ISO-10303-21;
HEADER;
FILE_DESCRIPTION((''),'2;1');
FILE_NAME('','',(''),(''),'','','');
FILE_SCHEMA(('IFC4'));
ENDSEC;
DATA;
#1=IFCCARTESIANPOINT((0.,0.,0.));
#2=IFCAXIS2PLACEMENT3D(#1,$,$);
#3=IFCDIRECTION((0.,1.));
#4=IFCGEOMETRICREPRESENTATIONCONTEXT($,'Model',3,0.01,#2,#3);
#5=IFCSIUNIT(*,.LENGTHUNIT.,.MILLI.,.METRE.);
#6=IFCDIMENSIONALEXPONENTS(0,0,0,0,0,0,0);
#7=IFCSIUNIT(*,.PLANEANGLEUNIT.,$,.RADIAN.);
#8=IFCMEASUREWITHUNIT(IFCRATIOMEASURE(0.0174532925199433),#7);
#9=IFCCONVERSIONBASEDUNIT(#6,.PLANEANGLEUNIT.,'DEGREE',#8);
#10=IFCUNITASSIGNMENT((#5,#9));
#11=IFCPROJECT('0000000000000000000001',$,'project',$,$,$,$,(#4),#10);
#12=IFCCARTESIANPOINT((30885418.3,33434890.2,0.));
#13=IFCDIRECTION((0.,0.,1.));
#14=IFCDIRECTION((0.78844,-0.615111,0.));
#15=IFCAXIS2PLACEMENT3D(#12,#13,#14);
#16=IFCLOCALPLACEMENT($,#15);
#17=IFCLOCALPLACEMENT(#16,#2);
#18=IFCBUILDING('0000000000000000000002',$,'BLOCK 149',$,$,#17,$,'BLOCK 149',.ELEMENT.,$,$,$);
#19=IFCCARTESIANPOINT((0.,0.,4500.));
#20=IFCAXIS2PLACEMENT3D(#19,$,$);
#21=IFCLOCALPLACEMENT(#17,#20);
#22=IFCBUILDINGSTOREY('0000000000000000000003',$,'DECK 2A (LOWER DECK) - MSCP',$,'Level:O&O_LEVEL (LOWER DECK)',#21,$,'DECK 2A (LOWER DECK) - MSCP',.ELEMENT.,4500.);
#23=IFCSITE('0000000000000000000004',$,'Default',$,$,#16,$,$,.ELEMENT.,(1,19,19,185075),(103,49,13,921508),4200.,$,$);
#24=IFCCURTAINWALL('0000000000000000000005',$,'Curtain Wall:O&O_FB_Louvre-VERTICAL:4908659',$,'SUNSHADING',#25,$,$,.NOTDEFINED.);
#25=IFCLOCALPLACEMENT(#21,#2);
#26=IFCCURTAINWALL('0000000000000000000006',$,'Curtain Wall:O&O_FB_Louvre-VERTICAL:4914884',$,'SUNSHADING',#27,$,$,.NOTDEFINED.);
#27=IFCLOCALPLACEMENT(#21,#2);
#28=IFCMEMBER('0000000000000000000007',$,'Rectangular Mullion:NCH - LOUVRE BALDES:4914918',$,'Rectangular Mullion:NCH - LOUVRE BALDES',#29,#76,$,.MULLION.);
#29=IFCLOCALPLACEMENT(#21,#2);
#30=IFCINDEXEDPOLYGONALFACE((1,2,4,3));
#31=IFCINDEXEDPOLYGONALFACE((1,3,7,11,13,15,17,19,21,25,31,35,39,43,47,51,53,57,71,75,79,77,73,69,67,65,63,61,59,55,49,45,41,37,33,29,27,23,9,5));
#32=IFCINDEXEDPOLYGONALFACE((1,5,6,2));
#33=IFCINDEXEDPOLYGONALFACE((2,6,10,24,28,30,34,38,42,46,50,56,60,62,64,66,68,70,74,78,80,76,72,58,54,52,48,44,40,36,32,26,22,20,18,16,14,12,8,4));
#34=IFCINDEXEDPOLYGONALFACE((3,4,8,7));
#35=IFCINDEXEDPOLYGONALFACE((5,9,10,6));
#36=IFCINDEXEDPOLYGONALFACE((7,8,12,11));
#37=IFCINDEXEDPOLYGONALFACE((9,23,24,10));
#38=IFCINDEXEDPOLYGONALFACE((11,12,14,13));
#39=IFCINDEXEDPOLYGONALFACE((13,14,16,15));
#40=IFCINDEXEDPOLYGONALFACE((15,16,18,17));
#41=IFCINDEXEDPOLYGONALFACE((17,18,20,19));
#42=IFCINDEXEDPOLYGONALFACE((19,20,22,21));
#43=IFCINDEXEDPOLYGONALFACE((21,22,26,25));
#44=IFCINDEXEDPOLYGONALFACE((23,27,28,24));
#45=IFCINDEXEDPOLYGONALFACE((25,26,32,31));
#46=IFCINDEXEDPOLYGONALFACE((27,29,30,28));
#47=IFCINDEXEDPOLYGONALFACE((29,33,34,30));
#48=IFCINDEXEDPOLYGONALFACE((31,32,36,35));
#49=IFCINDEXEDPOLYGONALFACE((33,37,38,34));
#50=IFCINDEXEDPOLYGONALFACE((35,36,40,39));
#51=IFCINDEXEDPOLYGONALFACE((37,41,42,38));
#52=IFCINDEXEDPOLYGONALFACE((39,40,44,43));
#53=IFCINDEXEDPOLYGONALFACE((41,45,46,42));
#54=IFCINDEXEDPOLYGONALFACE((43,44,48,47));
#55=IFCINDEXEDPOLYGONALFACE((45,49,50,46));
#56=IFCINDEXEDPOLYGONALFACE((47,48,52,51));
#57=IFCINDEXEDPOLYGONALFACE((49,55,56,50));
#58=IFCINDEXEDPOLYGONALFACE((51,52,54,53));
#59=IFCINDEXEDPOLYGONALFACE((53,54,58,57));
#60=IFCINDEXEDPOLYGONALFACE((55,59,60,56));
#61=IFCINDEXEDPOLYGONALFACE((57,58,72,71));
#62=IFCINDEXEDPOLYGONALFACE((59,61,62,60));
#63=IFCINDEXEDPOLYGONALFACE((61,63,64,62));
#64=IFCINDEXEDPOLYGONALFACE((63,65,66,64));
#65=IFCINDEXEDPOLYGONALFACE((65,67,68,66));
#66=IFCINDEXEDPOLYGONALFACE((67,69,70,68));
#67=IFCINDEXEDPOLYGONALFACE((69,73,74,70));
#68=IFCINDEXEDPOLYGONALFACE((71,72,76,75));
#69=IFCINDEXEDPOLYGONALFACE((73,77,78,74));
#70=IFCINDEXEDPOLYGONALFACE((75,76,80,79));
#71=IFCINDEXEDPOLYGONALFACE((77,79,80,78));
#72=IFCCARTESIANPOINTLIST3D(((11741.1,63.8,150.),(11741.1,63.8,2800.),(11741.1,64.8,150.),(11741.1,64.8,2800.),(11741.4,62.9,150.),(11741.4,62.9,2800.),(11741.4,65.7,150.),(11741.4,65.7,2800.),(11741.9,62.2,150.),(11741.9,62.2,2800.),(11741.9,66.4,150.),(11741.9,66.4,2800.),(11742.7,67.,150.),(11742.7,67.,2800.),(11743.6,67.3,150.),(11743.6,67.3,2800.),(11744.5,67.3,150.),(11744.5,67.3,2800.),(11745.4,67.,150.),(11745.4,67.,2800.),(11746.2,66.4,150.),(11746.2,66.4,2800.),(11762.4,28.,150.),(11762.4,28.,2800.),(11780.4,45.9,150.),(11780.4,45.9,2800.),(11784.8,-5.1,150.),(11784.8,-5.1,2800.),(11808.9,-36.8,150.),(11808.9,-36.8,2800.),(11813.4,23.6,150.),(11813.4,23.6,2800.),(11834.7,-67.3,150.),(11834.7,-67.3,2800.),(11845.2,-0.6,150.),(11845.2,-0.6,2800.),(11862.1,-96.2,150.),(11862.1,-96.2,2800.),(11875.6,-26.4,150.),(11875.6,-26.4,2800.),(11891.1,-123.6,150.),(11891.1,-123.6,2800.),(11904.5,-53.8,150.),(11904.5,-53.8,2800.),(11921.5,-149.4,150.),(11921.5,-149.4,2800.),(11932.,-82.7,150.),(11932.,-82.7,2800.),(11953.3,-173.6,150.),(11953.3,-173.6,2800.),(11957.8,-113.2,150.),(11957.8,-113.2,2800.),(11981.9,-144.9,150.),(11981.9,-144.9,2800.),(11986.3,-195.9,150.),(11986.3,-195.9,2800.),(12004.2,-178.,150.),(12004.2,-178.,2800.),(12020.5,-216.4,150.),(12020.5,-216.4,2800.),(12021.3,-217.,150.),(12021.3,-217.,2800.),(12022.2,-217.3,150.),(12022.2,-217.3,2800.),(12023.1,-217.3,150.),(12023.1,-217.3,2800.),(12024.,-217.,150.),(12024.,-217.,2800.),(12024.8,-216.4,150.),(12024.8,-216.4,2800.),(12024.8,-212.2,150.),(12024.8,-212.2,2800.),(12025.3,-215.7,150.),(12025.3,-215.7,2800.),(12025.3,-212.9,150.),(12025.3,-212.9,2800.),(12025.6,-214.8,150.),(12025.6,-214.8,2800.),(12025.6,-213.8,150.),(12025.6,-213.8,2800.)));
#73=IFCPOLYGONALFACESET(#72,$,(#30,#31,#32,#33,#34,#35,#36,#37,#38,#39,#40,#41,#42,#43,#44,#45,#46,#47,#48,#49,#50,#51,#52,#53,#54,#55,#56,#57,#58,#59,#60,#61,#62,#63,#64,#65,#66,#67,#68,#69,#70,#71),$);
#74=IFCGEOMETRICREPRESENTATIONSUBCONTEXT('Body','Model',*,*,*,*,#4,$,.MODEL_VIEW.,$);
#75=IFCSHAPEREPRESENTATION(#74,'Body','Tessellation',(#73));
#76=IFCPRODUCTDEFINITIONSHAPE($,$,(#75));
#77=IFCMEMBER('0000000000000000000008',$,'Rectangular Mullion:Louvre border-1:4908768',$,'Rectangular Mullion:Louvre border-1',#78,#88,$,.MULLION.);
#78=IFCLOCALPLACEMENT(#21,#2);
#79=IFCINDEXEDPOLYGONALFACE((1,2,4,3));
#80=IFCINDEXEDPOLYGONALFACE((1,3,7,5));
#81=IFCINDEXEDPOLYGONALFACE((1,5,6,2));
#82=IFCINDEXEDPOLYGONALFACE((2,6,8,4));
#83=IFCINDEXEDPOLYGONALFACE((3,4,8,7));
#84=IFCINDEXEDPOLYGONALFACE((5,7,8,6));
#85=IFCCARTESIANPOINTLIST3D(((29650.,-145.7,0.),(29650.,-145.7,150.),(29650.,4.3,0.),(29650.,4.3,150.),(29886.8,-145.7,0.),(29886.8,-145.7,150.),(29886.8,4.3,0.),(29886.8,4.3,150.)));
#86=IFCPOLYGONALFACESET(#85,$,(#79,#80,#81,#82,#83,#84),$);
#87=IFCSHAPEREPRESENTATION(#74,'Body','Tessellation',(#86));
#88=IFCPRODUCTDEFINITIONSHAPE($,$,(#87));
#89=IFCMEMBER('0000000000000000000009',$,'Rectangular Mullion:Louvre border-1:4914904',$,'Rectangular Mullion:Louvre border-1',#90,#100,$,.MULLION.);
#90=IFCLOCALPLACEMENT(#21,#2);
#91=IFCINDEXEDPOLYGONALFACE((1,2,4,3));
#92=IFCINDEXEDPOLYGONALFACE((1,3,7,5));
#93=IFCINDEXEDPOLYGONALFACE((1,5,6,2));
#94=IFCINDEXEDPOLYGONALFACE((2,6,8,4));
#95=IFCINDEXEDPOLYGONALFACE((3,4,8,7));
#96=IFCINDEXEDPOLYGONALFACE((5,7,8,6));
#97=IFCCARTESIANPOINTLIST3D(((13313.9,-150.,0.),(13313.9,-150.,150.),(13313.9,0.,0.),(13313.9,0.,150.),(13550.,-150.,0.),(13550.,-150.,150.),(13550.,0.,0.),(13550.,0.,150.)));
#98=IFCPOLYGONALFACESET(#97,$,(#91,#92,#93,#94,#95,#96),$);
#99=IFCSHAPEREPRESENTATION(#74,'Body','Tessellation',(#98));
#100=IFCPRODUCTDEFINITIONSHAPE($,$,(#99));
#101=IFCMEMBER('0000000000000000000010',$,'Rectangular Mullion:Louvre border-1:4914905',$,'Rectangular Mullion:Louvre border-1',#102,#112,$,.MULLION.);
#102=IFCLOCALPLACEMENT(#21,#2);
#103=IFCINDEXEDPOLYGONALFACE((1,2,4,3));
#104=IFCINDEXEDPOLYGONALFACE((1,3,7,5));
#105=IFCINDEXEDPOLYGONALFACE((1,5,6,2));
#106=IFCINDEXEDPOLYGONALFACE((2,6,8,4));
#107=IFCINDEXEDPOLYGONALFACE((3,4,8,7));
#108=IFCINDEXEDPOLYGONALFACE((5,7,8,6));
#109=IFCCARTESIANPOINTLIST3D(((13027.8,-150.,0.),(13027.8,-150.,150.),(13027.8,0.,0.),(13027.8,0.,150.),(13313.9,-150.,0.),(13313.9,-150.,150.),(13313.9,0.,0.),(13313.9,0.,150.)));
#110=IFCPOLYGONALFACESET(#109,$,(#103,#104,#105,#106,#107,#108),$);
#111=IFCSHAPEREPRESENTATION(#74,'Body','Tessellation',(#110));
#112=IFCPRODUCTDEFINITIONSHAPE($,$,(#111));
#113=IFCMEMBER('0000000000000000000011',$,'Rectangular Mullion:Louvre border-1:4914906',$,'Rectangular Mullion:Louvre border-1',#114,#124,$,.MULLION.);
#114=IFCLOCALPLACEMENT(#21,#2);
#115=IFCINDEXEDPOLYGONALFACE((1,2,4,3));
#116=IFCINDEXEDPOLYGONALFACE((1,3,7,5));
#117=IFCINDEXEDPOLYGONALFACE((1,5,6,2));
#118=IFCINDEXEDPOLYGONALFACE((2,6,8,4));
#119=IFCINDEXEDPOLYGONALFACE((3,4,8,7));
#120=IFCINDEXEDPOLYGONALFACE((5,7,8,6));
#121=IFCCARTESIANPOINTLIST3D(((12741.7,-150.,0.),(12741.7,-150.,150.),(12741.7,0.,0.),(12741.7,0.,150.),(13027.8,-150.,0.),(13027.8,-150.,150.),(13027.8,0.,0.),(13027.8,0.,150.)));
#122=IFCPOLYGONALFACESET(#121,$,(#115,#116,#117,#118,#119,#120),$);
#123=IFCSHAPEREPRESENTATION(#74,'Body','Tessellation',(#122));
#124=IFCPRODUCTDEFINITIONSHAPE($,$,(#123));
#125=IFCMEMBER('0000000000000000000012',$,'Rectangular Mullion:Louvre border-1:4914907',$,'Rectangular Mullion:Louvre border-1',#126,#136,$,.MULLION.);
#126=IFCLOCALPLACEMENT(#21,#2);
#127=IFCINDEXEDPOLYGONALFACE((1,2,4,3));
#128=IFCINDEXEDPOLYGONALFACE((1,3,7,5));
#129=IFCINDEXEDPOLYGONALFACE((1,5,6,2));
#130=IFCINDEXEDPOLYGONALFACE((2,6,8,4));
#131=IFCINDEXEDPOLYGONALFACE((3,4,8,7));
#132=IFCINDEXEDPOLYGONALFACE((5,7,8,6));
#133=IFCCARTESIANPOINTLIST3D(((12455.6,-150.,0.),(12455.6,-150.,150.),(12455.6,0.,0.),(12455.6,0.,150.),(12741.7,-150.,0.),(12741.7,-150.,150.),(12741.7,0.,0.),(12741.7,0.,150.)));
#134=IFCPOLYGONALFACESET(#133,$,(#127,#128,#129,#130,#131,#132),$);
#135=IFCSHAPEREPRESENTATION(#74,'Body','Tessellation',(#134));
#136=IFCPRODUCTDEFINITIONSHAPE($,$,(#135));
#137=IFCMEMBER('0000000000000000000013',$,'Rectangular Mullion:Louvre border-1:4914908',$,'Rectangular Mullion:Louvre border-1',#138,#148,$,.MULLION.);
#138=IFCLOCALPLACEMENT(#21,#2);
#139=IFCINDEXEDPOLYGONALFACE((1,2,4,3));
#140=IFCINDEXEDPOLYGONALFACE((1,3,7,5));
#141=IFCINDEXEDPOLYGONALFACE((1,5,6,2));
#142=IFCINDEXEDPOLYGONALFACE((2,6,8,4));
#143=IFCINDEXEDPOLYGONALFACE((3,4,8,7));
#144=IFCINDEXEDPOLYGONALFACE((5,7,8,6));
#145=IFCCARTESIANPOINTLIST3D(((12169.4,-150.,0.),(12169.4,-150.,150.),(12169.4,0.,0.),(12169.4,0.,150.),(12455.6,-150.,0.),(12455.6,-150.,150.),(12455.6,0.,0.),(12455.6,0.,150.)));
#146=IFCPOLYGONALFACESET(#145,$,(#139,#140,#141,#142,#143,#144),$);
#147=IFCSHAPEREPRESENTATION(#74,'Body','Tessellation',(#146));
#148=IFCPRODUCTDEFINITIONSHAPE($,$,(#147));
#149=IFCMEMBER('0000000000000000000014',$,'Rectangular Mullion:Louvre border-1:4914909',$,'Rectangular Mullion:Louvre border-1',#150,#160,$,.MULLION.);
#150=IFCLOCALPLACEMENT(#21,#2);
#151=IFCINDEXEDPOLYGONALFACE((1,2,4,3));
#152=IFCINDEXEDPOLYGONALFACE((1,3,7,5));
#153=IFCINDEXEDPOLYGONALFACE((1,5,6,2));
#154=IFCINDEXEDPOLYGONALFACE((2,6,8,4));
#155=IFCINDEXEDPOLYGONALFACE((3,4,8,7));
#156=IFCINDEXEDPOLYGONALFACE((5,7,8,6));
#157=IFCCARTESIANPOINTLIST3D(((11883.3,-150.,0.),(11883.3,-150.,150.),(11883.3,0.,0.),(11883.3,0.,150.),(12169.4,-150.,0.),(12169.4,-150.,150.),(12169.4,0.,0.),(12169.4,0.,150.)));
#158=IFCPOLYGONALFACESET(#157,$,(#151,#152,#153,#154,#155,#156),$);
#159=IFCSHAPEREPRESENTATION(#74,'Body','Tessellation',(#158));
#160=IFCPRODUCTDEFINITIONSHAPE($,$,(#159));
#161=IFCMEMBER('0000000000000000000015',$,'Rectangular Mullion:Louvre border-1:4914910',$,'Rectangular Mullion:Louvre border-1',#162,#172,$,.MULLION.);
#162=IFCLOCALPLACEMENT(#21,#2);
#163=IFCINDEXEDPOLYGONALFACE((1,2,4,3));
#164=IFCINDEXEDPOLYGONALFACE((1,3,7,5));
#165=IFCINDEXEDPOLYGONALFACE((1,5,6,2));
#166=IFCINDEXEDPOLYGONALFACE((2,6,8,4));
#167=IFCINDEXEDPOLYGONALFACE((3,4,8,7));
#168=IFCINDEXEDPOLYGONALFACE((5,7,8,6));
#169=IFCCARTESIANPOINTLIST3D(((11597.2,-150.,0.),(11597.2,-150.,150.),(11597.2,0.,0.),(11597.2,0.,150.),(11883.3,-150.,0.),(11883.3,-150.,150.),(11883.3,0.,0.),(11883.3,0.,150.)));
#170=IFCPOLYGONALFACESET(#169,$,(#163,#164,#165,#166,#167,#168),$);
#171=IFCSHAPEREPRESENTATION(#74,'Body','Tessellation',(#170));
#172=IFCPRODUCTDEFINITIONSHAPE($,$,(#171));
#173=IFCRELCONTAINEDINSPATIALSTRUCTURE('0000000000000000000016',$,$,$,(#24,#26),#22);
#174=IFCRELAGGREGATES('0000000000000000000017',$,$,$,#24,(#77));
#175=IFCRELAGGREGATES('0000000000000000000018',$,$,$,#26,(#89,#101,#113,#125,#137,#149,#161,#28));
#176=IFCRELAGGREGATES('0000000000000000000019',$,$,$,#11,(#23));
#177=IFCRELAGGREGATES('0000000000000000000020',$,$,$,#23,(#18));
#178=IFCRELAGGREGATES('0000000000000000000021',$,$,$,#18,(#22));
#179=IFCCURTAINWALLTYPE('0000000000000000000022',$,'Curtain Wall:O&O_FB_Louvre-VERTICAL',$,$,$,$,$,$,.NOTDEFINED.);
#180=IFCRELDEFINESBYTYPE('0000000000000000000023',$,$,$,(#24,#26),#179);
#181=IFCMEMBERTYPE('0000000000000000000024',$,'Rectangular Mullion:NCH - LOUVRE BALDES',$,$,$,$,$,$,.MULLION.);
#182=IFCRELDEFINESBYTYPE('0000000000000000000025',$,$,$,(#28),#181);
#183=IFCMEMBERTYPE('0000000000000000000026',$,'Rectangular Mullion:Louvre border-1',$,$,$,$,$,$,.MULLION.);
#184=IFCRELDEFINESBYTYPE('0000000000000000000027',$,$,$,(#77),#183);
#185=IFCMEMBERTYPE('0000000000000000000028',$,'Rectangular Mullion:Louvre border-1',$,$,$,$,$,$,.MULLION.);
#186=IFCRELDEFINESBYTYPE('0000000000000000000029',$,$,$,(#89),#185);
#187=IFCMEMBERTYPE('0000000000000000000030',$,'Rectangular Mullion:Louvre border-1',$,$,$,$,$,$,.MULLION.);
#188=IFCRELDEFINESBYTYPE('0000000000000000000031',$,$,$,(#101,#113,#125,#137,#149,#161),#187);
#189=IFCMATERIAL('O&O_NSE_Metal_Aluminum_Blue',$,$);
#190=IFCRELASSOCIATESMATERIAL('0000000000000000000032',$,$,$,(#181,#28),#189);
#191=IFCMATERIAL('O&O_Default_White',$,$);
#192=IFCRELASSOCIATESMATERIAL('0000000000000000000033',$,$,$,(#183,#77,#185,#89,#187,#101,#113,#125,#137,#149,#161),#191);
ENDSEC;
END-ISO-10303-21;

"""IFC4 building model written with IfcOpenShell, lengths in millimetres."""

from ifc_helpers import new_model, entity, si_unit, converted_unit, direction, frame, origin, place, context, subcontext, project, spatial, indexed_curve, outline, extrude, source, transform, mapped, material, type_object, type_shapes, element, aggregate, save


model = new_model("IFC4")

# Units and contexts
model_context = context("Model", 3, precision=0.01, world=origin(), true_north=direction((0.0, 1.0)))
body_context = subcontext(model_context, "Body", "Model", "MODEL_VIEW")
ifc_project = project(units=[si_unit("LENGTHUNIT", "METRE", prefix="MILLI"), converted_unit("PLANEANGLEUNIT", "DEGREE", entity("IfcRatioMeasure", 0.0174532925199433), si_unit("PLANEANGLEUNIT", "RADIAN"), dimensions=[0, 0, 0, 0, 0, 0, 0])], contexts=[model_context])

# Site, building, storey
site_placement = place(None, frame((30885418.3, 33434890.2, 0.0), z_axis=(0.0, 0.0, 1.0), x_axis=(0.78844, -0.615111, 0.0)))
site = spatial("IfcSite", under=ifc_project, at=site_placement, Name="Default", CompositionType="ELEMENT", RefLatitude=(1, 19, 19, 185075), RefLongitude=(103, 49, 13, 921508), RefElevation=4200.0)
building_placement = place(site_placement, origin())
building = spatial("IfcBuilding", under=site, at=building_placement, Name="BLOCK 149", LongName="BLOCK 149", CompositionType="ELEMENT")
storey_placement = place(building_placement, frame((0.0, 0.0, 4500.0)))
storey = spatial("IfcBuildingStorey", under=building, at=storey_placement, Name="DECK 2A (LOWER DECK) - MSCP", ObjectType="Level:O&O_LEVEL (LOWER DECK)", LongName="DECK 2A (LOWER DECK) - MSCP", CompositionType="ELEMENT", Elevation=4500.0)

# Curtain wall
curtain_wall_type = type_object("IfcCurtainWallType", Name="Curtain Wall:O&O_FB_Louvre-VERTICAL", PredefinedType="NOTDEFINED")
curtain_wall_1_placement = place(storey_placement, frame((0.0, 0.0, -4500.0)))
curtain_wall_1 = element("IfcCurtainWall", 1, at=curtain_wall_1_placement, inside=storey, type_object=curtain_wall_type, Name="Curtain Wall:O&O_FB_Louvre-VERTICAL:4908659", ObjectType="SUNSHADING", PredefinedType="NOTDEFINED")
ifc_material_1 = material(Name="O&O_Default_White")
placement = place(building_placement, origin())

# Curtain wall
curtain_wall_2_placement = place(storey_placement, frame((0.0, 0.0, -4500.0)))
curtain_wall_2 = element("IfcCurtainWall", 2, at=curtain_wall_2_placement, inside=storey, type_object=curtain_wall_type, Name="Curtain Wall:O&O_FB_Louvre-VERTICAL:4914884", ObjectType="SUNSHADING", PredefinedType="NOTDEFINED")

# Members
ifc_material_2 = material(Name="O&O_NSE_Metal_Aluminum_Blue")
member_type_1 = type_object("IfcMemberType", Name="Rectangular Mullion:NCH - LOUVRE BALDES", PredefinedType="MULLION", material=ifc_material_2)
shared_shape_1 = source(origin(), body_context, "Body", "SweptSolid", [
    extrude(outline(indexed_curve([(55.9, -188.9), (54.8, -149.1), (51.6, -109.3), (46.1, -69.8), (38.6, -30.6), (28.9, 8.1), (17.1, 46.2), (3.3, 83.6), (-12.6, 120.2), (-30.4, 155.9), (-50.1, 190.5), (-50.5, 191.4), (-51.1, 192.1), (-52.0, 192.5), (-52.9, 192.7), (-53.8, 192.6), (-54.7, 192.2), (-55.4, 191.6), (-55.8, 190.8), (-56.0, 189.9), (-55.9, 188.9), (-54.8, 149.1), (-51.6, 109.3), (-46.1, 69.8), (-38.6, 30.6), (-28.9, -8.1), (-17.1, -46.2), (-3.3, -83.6), (12.6, -120.2), (30.4, -155.9), (50.1, -190.5), (50.5, -191.4), (51.1, -192.1), (52.0, -192.5), (52.9, -192.7), (53.8, -192.6), (54.7, -192.2), (55.4, -191.6), (55.8, -190.8), (56.0, -189.9), (55.9, -188.9)], self_intersect=False)), frame((0.0, 0.0, -2650.0), z_axis=(0.0, 0.0, 1.0), x_axis=(0.490779, -0.871284, 0.0)), (0.0, 0.0, 1.0), 2650.0),
])
type_shapes(member_type_1, [shared_shape_1])
member_1_placement = place(storey_placement, frame((11883.3, -75.0, 150.0), z_axis=(0.0, 0.0, -1.0), x_axis=(-1.0, 0.0, 0.0)))
member_1 = element("IfcMember", 3, at=member_1_placement, type_object=member_type_1, material=ifc_material_2, Name="Rectangular Mullion:NCH - LOUVRE BALDES:4914918", ObjectType="Rectangular Mullion:NCH - LOUVRE BALDES", PredefinedType="MULLION", context=body_context, shape_type="MappedRepresentation", body=[
    mapped(shared_shape_1, transform((0.0, 0.0, 0.0), scale=1.0)),
])
member_type_2 = type_object("IfcMemberType", Name="Rectangular Mullion:Louvre border-1", PredefinedType="MULLION", material=ifc_material_1)
shared_shape_2 = source(origin(), body_context, "Body", "SweptSolid", [
    extrude(outline(indexed_curve([(-75.0, -75.0), (75.0, -75.0), (75.0, 75.0), (-75.0, 75.0), (-75.0, -75.0)], self_intersect=False)), frame((-75.0, 0.0, -236.8), z_axis=(0.0, 0.0, 1.0), x_axis=(0.0, -1.0, 0.0)), (0.0, 0.0, 1.0), 236.8),
])
type_shapes(member_type_2, [shared_shape_2])
member_2_placement = place(placement, frame((29886.8, -70.7, 4500.0), z_axis=(1.0, 0.0, 0.0), x_axis=(0.0, 0.0, -1.0)))
member_2 = element("IfcMember", 4, at=member_2_placement, type_object=member_type_2, material=ifc_material_1, Name="Rectangular Mullion:Louvre border-1:4908768", ObjectType="Rectangular Mullion:Louvre border-1", PredefinedType="MULLION", context=body_context, shape_type="MappedRepresentation", body=[
    mapped(shared_shape_2, transform((0.0, 0.0, 0.0), scale=1.0)),
])
aggregate(curtain_wall_1, [member_2])
member_type_3 = type_object("IfcMemberType", Name="Rectangular Mullion:Louvre border-1", PredefinedType="MULLION", material=ifc_material_1)
shared_shape_3 = source(origin(), body_context, "Body", "SweptSolid", [
    extrude(outline(indexed_curve([(-75.0, -75.0), (75.0, -75.0), (75.0, 75.0), (-75.0, 75.0), (-75.0, -75.0)], self_intersect=False)), frame((-75.0, 0.0, -236.1), z_axis=(0.0, 0.0, 1.0), x_axis=(0.0, -1.0, 0.0)), (0.0, 0.0, 1.0), 236.1),
])
type_shapes(member_type_3, [shared_shape_3])
member_3_placement = place(storey_placement, frame((13550.0, -75.0, 0.0), z_axis=(1.0, 0.0, 0.0), x_axis=(0.0, 0.0, -1.0)))
member_3 = element("IfcMember", 5, at=member_3_placement, type_object=member_type_3, material=ifc_material_1, Name="Rectangular Mullion:Louvre border-1:4914904", ObjectType="Rectangular Mullion:Louvre border-1", PredefinedType="MULLION", context=body_context, shape_type="MappedRepresentation", body=[
    mapped(shared_shape_3, transform((0.0, 0.0, 0.0), scale=1.0)),
])
member_type_4 = type_object("IfcMemberType", Name="Rectangular Mullion:Louvre border-1", PredefinedType="MULLION", material=ifc_material_1)
shared_shape_4 = source(origin(), body_context, "Body", "SweptSolid", [
    extrude(outline(indexed_curve([(-75.0, -75.0), (75.0, -75.0), (75.0, 75.0), (-75.0, 75.0), (-75.0, -75.0)], self_intersect=False)), frame((-75.0, 0.0, -286.1), z_axis=(0.0, 0.0, 1.0), x_axis=(0.0, -1.0, 0.0)), (0.0, 0.0, 1.0), 286.1),
])
type_shapes(member_type_4, [shared_shape_4])
member_4_placement = place(storey_placement, frame((13313.9, -75.0, 0.0), z_axis=(1.0, 0.0, 0.0), x_axis=(0.0, 0.0, -1.0)))
member_4 = element("IfcMember", 6, at=member_4_placement, type_object=member_type_4, material=ifc_material_1, Name="Rectangular Mullion:Louvre border-1:4914905", ObjectType="Rectangular Mullion:Louvre border-1", PredefinedType="MULLION", context=body_context, shape_type="MappedRepresentation", body=[
    mapped(shared_shape_4, transform((0.0, 0.0, 0.0), scale=1.0)),
])
member_5_placement = place(storey_placement, frame((13027.8, -75.0, 0.0), z_axis=(1.0, 0.0, 0.0), x_axis=(0.0, 0.0, -1.0)))
member_5 = element("IfcMember", 7, at=member_5_placement, type_object=member_type_4, material=ifc_material_1, Name="Rectangular Mullion:Louvre border-1:4914906", ObjectType="Rectangular Mullion:Louvre border-1", PredefinedType="MULLION", context=body_context, shape_type="MappedRepresentation", body=[
    mapped(shared_shape_4, transform((0.0, 0.0, 0.0), scale=1.0)),
])
member_6_placement = place(storey_placement, frame((12741.7, -75.0, 0.0), z_axis=(1.0, 0.0, 0.0), x_axis=(0.0, 0.0, -1.0)))
member_6 = element("IfcMember", 8, at=member_6_placement, type_object=member_type_4, material=ifc_material_1, Name="Rectangular Mullion:Louvre border-1:4914907", ObjectType="Rectangular Mullion:Louvre border-1", PredefinedType="MULLION", context=body_context, shape_type="MappedRepresentation", body=[
    mapped(shared_shape_4, transform((0.0, 0.0, 0.0), scale=1.0)),
])
member_7_placement = place(storey_placement, frame((12455.6, -75.0, 0.0), z_axis=(1.0, 0.0, 0.0), x_axis=(0.0, 0.0, -1.0)))
member_7 = element("IfcMember", 9, at=member_7_placement, type_object=member_type_4, material=ifc_material_1, Name="Rectangular Mullion:Louvre border-1:4914908", ObjectType="Rectangular Mullion:Louvre border-1", PredefinedType="MULLION", context=body_context, shape_type="MappedRepresentation", body=[
    mapped(shared_shape_4, transform((0.0, 0.0, 0.0), scale=1.0)),
])
member_8_placement = place(storey_placement, frame((12169.4, -75.0, 0.0), z_axis=(1.0, 0.0, 0.0), x_axis=(0.0, 0.0, -1.0)))
member_8 = element("IfcMember", 10, at=member_8_placement, type_object=member_type_4, material=ifc_material_1, Name="Rectangular Mullion:Louvre border-1:4914909", ObjectType="Rectangular Mullion:Louvre border-1", PredefinedType="MULLION", context=body_context, shape_type="MappedRepresentation", body=[
    mapped(shared_shape_4, transform((0.0, 0.0, 0.0), scale=1.0)),
])
member_9_placement = place(storey_placement, frame((11883.3, -75.0, 0.0), z_axis=(1.0, 0.0, 0.0), x_axis=(0.0, 0.0, -1.0)))
member_9 = element("IfcMember", 11, at=member_9_placement, type_object=member_type_4, material=ifc_material_1, Name="Rectangular Mullion:Louvre border-1:4914910", ObjectType="Rectangular Mullion:Louvre border-1", PredefinedType="MULLION", context=body_context, shape_type="MappedRepresentation", body=[
    mapped(shared_shape_4, transform((0.0, 0.0, 0.0), scale=1.0)),
])
aggregate(curtain_wall_2, [member_3, member_4, member_5, member_6, member_7, member_8, member_9, member_1])

save(model, "model.ifc")
